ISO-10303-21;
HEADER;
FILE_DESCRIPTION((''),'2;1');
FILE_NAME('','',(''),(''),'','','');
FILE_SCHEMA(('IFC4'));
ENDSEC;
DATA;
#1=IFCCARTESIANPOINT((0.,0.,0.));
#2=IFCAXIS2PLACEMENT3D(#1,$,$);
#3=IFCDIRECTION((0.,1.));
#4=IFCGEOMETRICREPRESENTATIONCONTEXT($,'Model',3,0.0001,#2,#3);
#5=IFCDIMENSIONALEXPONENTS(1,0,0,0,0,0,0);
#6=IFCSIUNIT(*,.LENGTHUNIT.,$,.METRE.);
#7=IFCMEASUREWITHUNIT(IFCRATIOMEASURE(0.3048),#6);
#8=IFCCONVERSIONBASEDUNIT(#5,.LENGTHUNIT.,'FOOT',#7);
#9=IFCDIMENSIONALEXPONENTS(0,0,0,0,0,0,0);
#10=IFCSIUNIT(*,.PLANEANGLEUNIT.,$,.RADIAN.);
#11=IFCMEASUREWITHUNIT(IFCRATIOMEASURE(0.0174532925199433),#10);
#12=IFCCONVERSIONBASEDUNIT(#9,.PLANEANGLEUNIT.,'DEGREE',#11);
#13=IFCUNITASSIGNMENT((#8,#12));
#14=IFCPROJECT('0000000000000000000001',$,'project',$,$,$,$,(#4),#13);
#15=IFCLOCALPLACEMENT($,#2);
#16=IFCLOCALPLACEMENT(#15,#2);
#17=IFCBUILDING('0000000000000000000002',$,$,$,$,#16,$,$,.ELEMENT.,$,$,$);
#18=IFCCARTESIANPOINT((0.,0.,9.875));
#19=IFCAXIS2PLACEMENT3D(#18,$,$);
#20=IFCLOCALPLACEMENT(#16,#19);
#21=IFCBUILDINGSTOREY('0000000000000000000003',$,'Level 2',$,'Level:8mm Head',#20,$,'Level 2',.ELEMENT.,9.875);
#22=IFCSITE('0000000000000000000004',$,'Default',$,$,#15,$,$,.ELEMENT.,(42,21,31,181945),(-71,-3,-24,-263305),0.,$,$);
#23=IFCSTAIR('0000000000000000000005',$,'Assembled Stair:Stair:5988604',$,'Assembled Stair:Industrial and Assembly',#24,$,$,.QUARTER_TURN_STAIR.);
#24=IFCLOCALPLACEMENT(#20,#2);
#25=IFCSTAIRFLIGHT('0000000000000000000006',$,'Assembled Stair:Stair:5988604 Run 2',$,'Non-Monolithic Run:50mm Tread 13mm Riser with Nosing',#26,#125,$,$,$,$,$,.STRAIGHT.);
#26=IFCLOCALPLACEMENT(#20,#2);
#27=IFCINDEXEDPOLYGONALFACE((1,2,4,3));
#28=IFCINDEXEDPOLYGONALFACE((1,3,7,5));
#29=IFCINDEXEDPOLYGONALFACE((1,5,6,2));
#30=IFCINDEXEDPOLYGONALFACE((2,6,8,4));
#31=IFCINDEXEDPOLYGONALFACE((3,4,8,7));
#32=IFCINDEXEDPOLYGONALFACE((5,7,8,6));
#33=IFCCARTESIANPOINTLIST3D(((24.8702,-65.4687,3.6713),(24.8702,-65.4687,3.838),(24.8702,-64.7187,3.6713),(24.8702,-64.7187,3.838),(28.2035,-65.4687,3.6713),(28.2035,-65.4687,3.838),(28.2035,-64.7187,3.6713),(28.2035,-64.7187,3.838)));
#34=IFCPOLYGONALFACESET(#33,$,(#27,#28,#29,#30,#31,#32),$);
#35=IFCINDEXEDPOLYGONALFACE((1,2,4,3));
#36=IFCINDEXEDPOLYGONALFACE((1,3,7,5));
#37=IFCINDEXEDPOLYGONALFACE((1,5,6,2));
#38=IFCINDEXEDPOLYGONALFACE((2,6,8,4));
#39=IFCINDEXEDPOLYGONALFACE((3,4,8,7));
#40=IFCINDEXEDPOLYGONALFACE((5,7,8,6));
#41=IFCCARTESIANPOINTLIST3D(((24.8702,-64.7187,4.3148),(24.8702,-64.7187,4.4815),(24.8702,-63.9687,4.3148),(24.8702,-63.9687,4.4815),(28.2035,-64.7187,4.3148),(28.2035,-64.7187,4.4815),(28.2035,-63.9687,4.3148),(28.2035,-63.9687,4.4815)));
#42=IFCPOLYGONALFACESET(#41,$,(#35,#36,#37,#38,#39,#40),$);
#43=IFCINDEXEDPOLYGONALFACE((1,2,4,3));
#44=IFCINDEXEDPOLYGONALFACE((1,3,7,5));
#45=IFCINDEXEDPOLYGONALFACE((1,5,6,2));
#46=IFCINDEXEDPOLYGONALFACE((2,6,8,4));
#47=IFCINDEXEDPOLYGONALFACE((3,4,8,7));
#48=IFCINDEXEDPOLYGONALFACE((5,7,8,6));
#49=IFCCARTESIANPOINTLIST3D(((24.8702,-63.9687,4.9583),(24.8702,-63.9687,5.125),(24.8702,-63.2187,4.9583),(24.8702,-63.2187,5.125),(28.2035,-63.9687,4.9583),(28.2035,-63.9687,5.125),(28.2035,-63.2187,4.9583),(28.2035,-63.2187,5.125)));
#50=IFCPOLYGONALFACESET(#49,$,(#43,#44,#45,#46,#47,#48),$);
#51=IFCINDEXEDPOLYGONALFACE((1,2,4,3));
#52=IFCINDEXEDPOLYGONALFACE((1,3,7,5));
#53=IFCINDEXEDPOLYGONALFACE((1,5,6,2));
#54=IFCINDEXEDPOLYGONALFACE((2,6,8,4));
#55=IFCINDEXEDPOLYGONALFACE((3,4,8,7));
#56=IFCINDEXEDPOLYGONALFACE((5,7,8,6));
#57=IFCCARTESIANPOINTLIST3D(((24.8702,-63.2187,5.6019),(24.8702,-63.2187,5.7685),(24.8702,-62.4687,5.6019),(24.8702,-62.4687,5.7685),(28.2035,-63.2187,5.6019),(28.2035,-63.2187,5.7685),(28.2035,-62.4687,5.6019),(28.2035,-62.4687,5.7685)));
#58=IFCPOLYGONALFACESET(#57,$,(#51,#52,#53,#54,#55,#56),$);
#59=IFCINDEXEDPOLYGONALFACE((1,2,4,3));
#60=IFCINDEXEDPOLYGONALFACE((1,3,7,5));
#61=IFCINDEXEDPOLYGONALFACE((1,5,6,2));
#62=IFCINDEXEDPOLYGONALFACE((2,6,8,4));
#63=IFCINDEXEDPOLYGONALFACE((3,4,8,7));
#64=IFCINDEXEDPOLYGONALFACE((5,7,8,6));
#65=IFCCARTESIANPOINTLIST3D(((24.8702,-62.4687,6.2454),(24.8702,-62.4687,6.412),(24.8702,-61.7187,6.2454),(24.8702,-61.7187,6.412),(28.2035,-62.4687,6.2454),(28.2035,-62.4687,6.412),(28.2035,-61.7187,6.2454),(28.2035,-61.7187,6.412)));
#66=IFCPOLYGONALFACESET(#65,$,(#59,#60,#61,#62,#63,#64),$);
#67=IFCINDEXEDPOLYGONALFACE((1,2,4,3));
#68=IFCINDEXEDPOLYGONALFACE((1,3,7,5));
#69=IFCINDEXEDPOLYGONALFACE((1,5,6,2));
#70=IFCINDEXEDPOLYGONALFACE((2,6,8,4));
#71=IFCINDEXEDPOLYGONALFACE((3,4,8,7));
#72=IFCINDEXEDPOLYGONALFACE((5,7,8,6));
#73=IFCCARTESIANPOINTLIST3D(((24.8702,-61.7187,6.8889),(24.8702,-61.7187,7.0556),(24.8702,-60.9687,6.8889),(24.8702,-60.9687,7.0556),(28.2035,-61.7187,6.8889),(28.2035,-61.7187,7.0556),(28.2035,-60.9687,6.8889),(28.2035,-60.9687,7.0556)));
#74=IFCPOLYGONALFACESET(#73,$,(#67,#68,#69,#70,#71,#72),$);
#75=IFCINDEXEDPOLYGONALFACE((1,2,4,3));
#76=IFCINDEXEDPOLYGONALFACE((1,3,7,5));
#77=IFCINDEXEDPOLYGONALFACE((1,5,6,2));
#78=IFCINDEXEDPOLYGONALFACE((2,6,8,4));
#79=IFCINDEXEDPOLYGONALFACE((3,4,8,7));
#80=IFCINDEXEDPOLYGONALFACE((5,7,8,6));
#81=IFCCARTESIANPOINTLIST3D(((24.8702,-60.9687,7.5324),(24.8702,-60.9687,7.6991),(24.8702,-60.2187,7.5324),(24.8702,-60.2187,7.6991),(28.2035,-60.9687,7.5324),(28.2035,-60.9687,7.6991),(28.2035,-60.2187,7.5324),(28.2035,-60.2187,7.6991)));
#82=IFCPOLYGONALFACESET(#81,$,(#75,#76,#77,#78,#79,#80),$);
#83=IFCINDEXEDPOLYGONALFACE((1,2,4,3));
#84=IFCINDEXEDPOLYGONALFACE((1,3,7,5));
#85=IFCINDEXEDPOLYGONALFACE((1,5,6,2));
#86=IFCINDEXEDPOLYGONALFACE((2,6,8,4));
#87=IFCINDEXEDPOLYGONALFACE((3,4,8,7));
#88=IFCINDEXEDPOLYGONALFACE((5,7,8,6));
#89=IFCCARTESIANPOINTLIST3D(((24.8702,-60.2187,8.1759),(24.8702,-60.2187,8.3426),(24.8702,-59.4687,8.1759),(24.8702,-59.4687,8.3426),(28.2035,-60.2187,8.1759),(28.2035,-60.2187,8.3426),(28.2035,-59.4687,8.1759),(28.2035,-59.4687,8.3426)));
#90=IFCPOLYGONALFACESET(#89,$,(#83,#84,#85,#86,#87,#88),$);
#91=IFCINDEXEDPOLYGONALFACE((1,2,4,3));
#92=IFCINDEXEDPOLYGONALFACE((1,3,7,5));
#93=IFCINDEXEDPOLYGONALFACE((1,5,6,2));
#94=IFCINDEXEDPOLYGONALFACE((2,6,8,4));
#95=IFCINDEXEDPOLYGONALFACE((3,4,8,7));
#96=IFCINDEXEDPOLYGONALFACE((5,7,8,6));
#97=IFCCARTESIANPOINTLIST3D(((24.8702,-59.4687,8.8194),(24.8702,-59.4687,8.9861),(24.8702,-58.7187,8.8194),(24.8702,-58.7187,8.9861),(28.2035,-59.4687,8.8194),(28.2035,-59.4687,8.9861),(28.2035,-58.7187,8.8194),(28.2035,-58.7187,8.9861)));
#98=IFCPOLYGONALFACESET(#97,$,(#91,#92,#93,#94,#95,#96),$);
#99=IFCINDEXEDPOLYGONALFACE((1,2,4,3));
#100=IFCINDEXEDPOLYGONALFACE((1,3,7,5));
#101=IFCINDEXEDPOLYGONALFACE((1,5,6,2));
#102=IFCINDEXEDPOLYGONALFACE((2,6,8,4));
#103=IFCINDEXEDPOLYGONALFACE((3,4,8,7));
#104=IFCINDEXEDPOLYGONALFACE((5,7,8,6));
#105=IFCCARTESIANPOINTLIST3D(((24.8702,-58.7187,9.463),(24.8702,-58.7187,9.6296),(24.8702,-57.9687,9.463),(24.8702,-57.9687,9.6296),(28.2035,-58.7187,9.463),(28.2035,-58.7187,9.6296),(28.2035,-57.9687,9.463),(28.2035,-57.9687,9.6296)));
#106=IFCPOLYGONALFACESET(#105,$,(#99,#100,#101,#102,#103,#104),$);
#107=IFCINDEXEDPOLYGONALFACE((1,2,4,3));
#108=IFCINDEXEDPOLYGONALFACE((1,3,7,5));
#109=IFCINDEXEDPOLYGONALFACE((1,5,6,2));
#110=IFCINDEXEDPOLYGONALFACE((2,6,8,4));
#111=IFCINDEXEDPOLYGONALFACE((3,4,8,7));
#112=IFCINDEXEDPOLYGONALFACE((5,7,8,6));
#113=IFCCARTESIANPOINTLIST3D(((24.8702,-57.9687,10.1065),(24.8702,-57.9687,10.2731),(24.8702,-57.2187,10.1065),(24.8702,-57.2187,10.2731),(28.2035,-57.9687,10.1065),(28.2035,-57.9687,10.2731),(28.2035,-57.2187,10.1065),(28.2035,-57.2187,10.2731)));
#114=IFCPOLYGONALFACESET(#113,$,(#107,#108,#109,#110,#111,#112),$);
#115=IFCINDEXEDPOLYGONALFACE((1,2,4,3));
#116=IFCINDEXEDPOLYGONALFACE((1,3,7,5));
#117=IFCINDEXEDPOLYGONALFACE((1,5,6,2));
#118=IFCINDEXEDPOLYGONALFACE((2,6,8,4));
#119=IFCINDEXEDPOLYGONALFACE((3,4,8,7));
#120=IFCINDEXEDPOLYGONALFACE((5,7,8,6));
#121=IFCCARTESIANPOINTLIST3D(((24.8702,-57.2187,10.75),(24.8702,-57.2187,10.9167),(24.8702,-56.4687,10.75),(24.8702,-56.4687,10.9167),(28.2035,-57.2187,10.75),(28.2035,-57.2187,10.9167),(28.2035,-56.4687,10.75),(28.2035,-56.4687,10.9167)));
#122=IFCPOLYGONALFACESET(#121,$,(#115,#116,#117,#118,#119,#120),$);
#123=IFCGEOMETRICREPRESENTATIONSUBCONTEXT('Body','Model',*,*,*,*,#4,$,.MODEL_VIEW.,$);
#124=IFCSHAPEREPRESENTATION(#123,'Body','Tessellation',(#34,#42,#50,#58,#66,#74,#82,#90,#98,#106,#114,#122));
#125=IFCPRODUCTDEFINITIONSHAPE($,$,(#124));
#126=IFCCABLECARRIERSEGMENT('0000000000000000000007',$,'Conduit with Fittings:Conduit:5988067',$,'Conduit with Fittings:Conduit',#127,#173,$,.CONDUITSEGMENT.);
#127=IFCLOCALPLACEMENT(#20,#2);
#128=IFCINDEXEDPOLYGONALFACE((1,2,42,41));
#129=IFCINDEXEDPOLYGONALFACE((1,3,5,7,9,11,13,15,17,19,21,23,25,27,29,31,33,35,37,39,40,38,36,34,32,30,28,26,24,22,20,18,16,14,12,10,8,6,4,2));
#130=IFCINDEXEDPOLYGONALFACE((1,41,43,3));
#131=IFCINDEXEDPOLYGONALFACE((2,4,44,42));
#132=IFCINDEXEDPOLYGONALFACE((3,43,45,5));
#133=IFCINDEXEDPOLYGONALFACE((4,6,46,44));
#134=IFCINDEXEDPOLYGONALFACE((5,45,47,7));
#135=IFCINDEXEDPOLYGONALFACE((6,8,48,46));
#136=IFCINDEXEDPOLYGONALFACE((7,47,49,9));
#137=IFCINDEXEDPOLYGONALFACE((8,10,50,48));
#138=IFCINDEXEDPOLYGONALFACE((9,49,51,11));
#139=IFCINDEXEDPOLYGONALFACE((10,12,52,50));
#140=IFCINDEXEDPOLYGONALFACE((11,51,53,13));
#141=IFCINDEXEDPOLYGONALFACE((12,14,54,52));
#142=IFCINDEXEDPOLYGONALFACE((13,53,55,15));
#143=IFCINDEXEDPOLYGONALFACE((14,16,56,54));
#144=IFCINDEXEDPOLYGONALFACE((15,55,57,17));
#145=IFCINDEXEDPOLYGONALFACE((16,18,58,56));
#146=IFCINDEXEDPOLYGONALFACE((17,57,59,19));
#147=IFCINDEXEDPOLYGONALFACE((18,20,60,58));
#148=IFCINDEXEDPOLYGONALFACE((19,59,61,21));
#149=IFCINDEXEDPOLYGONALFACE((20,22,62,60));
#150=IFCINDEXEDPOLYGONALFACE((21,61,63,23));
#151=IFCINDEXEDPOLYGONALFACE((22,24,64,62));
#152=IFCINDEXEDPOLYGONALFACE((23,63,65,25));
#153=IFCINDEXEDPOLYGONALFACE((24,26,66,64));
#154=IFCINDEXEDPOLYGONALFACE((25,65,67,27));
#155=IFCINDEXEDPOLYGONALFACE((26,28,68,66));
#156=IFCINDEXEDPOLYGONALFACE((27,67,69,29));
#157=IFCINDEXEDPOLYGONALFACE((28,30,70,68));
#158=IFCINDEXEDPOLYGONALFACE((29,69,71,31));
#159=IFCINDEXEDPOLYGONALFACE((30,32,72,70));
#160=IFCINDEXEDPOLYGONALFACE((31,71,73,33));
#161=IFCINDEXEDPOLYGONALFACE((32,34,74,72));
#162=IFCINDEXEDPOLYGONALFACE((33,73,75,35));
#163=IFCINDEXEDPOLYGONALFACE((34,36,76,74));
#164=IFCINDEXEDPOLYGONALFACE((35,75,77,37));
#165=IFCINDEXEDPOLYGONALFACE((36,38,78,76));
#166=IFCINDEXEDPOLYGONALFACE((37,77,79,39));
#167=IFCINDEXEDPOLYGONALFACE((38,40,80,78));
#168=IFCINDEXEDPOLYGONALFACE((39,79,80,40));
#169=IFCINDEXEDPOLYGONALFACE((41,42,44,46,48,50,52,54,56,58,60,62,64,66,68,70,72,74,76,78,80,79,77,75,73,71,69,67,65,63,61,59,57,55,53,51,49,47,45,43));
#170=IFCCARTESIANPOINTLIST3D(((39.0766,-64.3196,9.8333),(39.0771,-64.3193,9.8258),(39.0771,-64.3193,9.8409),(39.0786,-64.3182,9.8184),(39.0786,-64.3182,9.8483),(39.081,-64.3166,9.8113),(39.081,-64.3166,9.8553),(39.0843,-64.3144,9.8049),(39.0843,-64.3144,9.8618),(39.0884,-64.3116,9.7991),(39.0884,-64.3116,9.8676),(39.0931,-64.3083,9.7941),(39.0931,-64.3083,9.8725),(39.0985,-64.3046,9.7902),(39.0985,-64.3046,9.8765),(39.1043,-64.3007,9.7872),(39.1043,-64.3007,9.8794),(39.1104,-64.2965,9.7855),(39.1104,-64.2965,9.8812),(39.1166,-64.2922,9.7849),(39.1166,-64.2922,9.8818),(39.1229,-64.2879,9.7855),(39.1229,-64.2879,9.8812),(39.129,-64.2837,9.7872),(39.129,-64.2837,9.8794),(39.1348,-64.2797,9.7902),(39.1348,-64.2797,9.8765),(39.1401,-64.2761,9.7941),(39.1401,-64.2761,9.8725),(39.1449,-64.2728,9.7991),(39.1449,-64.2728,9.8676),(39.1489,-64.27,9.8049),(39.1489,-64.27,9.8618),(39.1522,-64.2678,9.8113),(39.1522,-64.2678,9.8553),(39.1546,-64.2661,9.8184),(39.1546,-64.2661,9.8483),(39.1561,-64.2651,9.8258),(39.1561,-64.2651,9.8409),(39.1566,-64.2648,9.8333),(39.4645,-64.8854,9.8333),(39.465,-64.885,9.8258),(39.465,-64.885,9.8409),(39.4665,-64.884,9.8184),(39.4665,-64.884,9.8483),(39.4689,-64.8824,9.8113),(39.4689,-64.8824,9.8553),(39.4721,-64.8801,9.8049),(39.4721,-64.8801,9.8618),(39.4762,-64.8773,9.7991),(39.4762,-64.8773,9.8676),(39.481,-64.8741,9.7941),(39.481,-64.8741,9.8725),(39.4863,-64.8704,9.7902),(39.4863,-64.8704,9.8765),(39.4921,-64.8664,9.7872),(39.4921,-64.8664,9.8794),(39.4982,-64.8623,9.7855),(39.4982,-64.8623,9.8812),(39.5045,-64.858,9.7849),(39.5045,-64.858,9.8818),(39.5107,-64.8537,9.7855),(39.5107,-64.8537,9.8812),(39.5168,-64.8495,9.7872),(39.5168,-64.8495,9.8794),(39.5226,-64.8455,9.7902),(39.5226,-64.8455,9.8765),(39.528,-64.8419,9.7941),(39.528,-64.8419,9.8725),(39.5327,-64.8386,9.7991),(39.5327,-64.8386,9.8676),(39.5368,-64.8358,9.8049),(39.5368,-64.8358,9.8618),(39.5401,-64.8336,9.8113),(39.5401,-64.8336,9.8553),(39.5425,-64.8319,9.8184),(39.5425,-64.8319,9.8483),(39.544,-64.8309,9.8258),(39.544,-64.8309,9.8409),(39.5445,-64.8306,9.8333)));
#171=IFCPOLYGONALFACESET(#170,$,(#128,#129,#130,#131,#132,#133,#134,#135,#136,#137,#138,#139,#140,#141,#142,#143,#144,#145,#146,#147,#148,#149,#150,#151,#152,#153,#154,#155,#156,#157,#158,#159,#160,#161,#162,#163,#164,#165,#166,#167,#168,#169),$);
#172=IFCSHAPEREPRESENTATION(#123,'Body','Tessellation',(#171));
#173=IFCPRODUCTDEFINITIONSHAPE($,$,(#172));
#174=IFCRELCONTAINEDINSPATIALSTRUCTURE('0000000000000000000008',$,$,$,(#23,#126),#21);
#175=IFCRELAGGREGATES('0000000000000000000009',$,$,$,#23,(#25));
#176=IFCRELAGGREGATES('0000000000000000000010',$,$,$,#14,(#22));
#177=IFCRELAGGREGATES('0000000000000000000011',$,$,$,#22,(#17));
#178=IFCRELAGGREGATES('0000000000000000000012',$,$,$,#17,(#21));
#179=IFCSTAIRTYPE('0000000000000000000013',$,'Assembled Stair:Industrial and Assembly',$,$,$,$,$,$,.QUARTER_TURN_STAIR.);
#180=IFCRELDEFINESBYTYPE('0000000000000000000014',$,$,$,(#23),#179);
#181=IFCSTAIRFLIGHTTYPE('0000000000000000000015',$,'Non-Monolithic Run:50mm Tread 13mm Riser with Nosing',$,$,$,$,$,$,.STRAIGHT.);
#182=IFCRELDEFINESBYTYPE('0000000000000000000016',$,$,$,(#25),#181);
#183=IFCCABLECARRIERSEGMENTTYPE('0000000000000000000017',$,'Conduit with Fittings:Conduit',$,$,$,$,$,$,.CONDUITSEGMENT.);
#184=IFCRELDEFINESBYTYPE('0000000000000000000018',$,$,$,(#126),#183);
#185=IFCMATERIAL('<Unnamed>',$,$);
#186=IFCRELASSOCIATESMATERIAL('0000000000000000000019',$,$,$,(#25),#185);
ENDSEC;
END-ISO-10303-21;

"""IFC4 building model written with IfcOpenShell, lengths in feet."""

from ifc_helpers import new_model, entity, si_unit, converted_unit, direction, frame, origin, place, context, subcontext, project, spatial, indexed_curve, outline, extrude, material, type_object, element, aggregate, save


model = new_model("IFC4")

# Units and contexts
model_context = context("Model", 3, precision=0.0001, world=origin(), true_north=direction((0.0, 1.0)))
body_context = subcontext(model_context, "Body", "Model", "MODEL_VIEW")
ifc_project = project(units=[converted_unit("LENGTHUNIT", "FOOT", entity("IfcRatioMeasure", 0.3048), si_unit("LENGTHUNIT", "METRE"), dimensions=[1, 0, 0, 0, 0, 0, 0]), converted_unit("PLANEANGLEUNIT", "DEGREE", entity("IfcRatioMeasure", 0.0174532925199433), si_unit("PLANEANGLEUNIT", "RADIAN"), dimensions=[0, 0, 0, 0, 0, 0, 0])], contexts=[model_context])

# Site, building, storey
site_placement = place(None, origin())
site = spatial("IfcSite", under=ifc_project, at=site_placement, Name="Default", CompositionType="ELEMENT", RefLatitude=(42, 21, 31, 181945), RefLongitude=(-71, -3, -24, -263305), RefElevation=0.0)
building_placement = place(site_placement, origin())
building = spatial("IfcBuilding", under=site, at=building_placement, CompositionType="ELEMENT")
storey_placement = place(building_placement, frame((0.0, 0.0, 9.875)))
storey = spatial("IfcBuildingStorey", under=building, at=storey_placement, Name="Level 2", ObjectType="Level:8mm Head", LongName="Level 2", CompositionType="ELEMENT", Elevation=9.875)

# Stair
stair_type = type_object("IfcStairType", Name="Assembled Stair:Industrial and Assembly", PredefinedType="QUARTER_TURN_STAIR")
stair_placement = place(storey_placement, origin())
stair = element("IfcStair", 1, at=stair_placement, inside=storey, type_object=stair_type, Name="Assembled Stair:Stair:5988604", ObjectType="Assembled Stair:Industrial and Assembly", PredefinedType="QUARTER_TURN_STAIR")
ifc_material_1 = material(Name="<Unnamed>")

# Stair flight
stair_flight_type_1 = type_object("IfcStairFlightType", Name="Non-Monolithic Run:50mm Tread 13mm Riser with Nosing", PredefinedType="STRAIGHT")
stair_flight_1_placement = place(stair_placement, origin())
stair_flight_1 = element("IfcStairFlight", 2, at=stair_flight_1_placement, type_object=stair_flight_type_1, material=ifc_material_1, Name="Assembled Stair:Stair:5988604 Run 2", ObjectType="Non-Monolithic Run:50mm Tread 13mm Riser with Nosing", PredefinedType="STRAIGHT", context=body_context, shape_type="SweptSolid", body=[
    extrude(outline(indexed_curve([(-0.375, -1.6667), (0.375, -1.6667), (0.375, 1.6667), (-0.375, 1.6667), (-0.375, -1.6667)], self_intersect=False)), frame((26.5368, -65.0937, 3.6713), z_axis=(0.0, 0.0, 1.0), x_axis=(0.0, -1.0, 0.0)), (0.0, 0.0, 1.0), 0.1667),
    extrude(outline(indexed_curve([(-0.375, -1.6667), (0.375, -1.6667), (0.375, 1.6667), (-0.375, 1.6667), (-0.375, -1.6667)], self_intersect=False)), frame((26.5368, -64.3437, 4.3148), z_axis=(0.0, 0.0, 1.0), x_axis=(0.0, -1.0, 0.0)), (0.0, 0.0, 1.0), 0.1667),
    extrude(outline(indexed_curve([(-0.375, -1.6667), (0.375, -1.6667), (0.375, 1.6667), (-0.375, 1.6667), (-0.375, -1.6667)], self_intersect=False)), frame((26.5368, -63.5937, 4.9583), z_axis=(0.0, 0.0, 1.0), x_axis=(0.0, -1.0, 0.0)), (0.0, 0.0, 1.0), 0.1667),
    extrude(outline(indexed_curve([(-0.375, -1.6667), (0.375, -1.6667), (0.375, 1.6667), (-0.375, 1.6667), (-0.375, -1.6667)], self_intersect=False)), frame((26.5368, -62.8437, 5.6019), z_axis=(0.0, 0.0, 1.0), x_axis=(0.0, -1.0, 0.0)), (0.0, 0.0, 1.0), 0.1667),
    extrude(outline(indexed_curve([(-0.375, -1.6667), (0.375, -1.6667), (0.375, 1.6667), (-0.375, 1.6667), (-0.375, -1.6667)], self_intersect=False)), frame((26.5368, -62.0937, 6.2454), z_axis=(0.0, 0.0, 1.0), x_axis=(0.0, -1.0, 0.0)), (0.0, 0.0, 1.0), 0.1667),
    extrude(outline(indexed_curve([(-0.375, -1.6667), (0.375, -1.6667), (0.375, 1.6667), (-0.375, 1.6667), (-0.375, -1.6667)], self_intersect=False)), frame((26.5368, -61.3437, 6.8889), z_axis=(0.0, 0.0, 1.0), x_axis=(0.0, -1.0, 0.0)), (0.0, 0.0, 1.0), 0.1667),
    extrude(outline(indexed_curve([(-0.375, -1.6667), (0.375, -1.6667), (0.375, 1.6667), (-0.375, 1.6667), (-0.375, -1.6667)], self_intersect=False)), frame((26.5368, -60.5937, 7.5324), z_axis=(0.0, 0.0, 1.0), x_axis=(0.0, -1.0, 0.0)), (0.0, 0.0, 1.0), 0.1667),
    extrude(outline(indexed_curve([(-0.375, -1.6667), (0.375, -1.6667), (0.375, 1.6667), (-0.375, 1.6667), (-0.375, -1.6667)], self_intersect=False)), frame((26.5368, -59.8437, 8.1759), z_axis=(0.0, 0.0, 1.0), x_axis=(0.0, -1.0, 0.0)), (0.0, 0.0, 1.0), 0.1667),
    extrude(outline(indexed_curve([(-0.375, -1.6667), (0.375, -1.6667), (0.375, 1.6667), (-0.375, 1.6667), (-0.375, -1.6667)], self_intersect=False)), frame((26.5368, -59.0937, 8.8194), z_axis=(0.0, 0.0, 1.0), x_axis=(0.0, -1.0, 0.0)), (0.0, 0.0, 1.0), 0.1667),
    extrude(outline(indexed_curve([(-0.375, -1.6667), (0.375, -1.6667), (0.375, 1.6667), (-0.375, 1.6667), (-0.375, -1.6667)], self_intersect=False)), frame((26.5368, -58.3437, 9.463), z_axis=(0.0, 0.0, 1.0), x_axis=(0.0, -1.0, 0.0)), (0.0, 0.0, 1.0), 0.1667),
    extrude(outline(indexed_curve([(-0.375, -1.6667), (0.375, -1.6667), (0.375, 1.6667), (-0.375, 1.6667), (-0.375, -1.6667)], self_intersect=False)), frame((26.5368, -57.5937, 10.1065), z_axis=(0.0, 0.0, 1.0), x_axis=(0.0, -1.0, 0.0)), (0.0, 0.0, 1.0), 0.1667),
    extrude(outline(indexed_curve([(-0.375, -1.6667), (0.375, -1.6667), (0.375, 1.6667), (-0.375, 1.6667), (-0.375, -1.6667)], self_intersect=False)), frame((26.5368, -56.8437, 10.75), z_axis=(0.0, 0.0, 1.0), x_axis=(0.0, -1.0, 0.0)), (0.0, 0.0, 1.0), 0.1667),
])
aggregate(stair, [stair_flight_1])

# Cable carrier segment
cable_carrier_segment_type = type_object("IfcCableCarrierSegmentType", Name="Conduit with Fittings:Conduit", PredefinedType="CONDUITSEGMENT")
cable_carrier_segment_1_placement = place(storey_placement, origin())
element("IfcCableCarrierSegment", 3, at=cable_carrier_segment_1_placement, inside=storey, type_object=cable_carrier_segment_type, Name="Conduit with Fittings:Conduit:5988067", ObjectType="Conduit with Fittings:Conduit", PredefinedType="CONDUITSEGMENT", context=body_context, shape_type="SweptSolid", body=[
    extrude(outline(indexed_curve([(0.0485, 0.0), (0.0479, 0.0076), (0.0461, 0.015), (0.0432, 0.022), (0.0392, 0.0285), (0.0343, 0.0343), (0.0285, 0.0392), (0.022, 0.0432), (0.015, 0.0461), (0.0076, 0.0479), (0.0, 0.0485), (-0.0076, 0.0479), (-0.015, 0.0461), (-0.022, 0.0432), (-0.0285, 0.0392), (-0.0343, 0.0343), (-0.0392, 0.0285), (-0.0432, 0.022), (-0.0461, 0.015), (-0.0479, 0.0076), (-0.0485, 0.0), (-0.0479, -0.0076), (-0.0461, -0.015), (-0.0432, -0.022), (-0.0392, -0.0285), (-0.0343, -0.0343), (-0.0285, -0.0392), (-0.022, -0.0432), (-0.015, -0.0461), (-0.0076, -0.0479), (0.0, -0.0485), (0.0076, -0.0479), (0.015, -0.0461), (0.022, -0.0432), (0.0285, -0.0392), (0.0343, -0.0343), (0.0392, -0.0285), (0.0432, -0.022), (0.0461, -0.015), (0.0479, -0.0076), (0.0485, 0.0)], self_intersect=False)), frame((39.1166, -64.2922, 9.8333), z_axis=(0.565435, -0.824793, 0.0), x_axis=(-0.824793, -0.565435, 0.0)), (0.0, 0.0, 1.0), 0.686),
])

save(model, "model.ifc")
